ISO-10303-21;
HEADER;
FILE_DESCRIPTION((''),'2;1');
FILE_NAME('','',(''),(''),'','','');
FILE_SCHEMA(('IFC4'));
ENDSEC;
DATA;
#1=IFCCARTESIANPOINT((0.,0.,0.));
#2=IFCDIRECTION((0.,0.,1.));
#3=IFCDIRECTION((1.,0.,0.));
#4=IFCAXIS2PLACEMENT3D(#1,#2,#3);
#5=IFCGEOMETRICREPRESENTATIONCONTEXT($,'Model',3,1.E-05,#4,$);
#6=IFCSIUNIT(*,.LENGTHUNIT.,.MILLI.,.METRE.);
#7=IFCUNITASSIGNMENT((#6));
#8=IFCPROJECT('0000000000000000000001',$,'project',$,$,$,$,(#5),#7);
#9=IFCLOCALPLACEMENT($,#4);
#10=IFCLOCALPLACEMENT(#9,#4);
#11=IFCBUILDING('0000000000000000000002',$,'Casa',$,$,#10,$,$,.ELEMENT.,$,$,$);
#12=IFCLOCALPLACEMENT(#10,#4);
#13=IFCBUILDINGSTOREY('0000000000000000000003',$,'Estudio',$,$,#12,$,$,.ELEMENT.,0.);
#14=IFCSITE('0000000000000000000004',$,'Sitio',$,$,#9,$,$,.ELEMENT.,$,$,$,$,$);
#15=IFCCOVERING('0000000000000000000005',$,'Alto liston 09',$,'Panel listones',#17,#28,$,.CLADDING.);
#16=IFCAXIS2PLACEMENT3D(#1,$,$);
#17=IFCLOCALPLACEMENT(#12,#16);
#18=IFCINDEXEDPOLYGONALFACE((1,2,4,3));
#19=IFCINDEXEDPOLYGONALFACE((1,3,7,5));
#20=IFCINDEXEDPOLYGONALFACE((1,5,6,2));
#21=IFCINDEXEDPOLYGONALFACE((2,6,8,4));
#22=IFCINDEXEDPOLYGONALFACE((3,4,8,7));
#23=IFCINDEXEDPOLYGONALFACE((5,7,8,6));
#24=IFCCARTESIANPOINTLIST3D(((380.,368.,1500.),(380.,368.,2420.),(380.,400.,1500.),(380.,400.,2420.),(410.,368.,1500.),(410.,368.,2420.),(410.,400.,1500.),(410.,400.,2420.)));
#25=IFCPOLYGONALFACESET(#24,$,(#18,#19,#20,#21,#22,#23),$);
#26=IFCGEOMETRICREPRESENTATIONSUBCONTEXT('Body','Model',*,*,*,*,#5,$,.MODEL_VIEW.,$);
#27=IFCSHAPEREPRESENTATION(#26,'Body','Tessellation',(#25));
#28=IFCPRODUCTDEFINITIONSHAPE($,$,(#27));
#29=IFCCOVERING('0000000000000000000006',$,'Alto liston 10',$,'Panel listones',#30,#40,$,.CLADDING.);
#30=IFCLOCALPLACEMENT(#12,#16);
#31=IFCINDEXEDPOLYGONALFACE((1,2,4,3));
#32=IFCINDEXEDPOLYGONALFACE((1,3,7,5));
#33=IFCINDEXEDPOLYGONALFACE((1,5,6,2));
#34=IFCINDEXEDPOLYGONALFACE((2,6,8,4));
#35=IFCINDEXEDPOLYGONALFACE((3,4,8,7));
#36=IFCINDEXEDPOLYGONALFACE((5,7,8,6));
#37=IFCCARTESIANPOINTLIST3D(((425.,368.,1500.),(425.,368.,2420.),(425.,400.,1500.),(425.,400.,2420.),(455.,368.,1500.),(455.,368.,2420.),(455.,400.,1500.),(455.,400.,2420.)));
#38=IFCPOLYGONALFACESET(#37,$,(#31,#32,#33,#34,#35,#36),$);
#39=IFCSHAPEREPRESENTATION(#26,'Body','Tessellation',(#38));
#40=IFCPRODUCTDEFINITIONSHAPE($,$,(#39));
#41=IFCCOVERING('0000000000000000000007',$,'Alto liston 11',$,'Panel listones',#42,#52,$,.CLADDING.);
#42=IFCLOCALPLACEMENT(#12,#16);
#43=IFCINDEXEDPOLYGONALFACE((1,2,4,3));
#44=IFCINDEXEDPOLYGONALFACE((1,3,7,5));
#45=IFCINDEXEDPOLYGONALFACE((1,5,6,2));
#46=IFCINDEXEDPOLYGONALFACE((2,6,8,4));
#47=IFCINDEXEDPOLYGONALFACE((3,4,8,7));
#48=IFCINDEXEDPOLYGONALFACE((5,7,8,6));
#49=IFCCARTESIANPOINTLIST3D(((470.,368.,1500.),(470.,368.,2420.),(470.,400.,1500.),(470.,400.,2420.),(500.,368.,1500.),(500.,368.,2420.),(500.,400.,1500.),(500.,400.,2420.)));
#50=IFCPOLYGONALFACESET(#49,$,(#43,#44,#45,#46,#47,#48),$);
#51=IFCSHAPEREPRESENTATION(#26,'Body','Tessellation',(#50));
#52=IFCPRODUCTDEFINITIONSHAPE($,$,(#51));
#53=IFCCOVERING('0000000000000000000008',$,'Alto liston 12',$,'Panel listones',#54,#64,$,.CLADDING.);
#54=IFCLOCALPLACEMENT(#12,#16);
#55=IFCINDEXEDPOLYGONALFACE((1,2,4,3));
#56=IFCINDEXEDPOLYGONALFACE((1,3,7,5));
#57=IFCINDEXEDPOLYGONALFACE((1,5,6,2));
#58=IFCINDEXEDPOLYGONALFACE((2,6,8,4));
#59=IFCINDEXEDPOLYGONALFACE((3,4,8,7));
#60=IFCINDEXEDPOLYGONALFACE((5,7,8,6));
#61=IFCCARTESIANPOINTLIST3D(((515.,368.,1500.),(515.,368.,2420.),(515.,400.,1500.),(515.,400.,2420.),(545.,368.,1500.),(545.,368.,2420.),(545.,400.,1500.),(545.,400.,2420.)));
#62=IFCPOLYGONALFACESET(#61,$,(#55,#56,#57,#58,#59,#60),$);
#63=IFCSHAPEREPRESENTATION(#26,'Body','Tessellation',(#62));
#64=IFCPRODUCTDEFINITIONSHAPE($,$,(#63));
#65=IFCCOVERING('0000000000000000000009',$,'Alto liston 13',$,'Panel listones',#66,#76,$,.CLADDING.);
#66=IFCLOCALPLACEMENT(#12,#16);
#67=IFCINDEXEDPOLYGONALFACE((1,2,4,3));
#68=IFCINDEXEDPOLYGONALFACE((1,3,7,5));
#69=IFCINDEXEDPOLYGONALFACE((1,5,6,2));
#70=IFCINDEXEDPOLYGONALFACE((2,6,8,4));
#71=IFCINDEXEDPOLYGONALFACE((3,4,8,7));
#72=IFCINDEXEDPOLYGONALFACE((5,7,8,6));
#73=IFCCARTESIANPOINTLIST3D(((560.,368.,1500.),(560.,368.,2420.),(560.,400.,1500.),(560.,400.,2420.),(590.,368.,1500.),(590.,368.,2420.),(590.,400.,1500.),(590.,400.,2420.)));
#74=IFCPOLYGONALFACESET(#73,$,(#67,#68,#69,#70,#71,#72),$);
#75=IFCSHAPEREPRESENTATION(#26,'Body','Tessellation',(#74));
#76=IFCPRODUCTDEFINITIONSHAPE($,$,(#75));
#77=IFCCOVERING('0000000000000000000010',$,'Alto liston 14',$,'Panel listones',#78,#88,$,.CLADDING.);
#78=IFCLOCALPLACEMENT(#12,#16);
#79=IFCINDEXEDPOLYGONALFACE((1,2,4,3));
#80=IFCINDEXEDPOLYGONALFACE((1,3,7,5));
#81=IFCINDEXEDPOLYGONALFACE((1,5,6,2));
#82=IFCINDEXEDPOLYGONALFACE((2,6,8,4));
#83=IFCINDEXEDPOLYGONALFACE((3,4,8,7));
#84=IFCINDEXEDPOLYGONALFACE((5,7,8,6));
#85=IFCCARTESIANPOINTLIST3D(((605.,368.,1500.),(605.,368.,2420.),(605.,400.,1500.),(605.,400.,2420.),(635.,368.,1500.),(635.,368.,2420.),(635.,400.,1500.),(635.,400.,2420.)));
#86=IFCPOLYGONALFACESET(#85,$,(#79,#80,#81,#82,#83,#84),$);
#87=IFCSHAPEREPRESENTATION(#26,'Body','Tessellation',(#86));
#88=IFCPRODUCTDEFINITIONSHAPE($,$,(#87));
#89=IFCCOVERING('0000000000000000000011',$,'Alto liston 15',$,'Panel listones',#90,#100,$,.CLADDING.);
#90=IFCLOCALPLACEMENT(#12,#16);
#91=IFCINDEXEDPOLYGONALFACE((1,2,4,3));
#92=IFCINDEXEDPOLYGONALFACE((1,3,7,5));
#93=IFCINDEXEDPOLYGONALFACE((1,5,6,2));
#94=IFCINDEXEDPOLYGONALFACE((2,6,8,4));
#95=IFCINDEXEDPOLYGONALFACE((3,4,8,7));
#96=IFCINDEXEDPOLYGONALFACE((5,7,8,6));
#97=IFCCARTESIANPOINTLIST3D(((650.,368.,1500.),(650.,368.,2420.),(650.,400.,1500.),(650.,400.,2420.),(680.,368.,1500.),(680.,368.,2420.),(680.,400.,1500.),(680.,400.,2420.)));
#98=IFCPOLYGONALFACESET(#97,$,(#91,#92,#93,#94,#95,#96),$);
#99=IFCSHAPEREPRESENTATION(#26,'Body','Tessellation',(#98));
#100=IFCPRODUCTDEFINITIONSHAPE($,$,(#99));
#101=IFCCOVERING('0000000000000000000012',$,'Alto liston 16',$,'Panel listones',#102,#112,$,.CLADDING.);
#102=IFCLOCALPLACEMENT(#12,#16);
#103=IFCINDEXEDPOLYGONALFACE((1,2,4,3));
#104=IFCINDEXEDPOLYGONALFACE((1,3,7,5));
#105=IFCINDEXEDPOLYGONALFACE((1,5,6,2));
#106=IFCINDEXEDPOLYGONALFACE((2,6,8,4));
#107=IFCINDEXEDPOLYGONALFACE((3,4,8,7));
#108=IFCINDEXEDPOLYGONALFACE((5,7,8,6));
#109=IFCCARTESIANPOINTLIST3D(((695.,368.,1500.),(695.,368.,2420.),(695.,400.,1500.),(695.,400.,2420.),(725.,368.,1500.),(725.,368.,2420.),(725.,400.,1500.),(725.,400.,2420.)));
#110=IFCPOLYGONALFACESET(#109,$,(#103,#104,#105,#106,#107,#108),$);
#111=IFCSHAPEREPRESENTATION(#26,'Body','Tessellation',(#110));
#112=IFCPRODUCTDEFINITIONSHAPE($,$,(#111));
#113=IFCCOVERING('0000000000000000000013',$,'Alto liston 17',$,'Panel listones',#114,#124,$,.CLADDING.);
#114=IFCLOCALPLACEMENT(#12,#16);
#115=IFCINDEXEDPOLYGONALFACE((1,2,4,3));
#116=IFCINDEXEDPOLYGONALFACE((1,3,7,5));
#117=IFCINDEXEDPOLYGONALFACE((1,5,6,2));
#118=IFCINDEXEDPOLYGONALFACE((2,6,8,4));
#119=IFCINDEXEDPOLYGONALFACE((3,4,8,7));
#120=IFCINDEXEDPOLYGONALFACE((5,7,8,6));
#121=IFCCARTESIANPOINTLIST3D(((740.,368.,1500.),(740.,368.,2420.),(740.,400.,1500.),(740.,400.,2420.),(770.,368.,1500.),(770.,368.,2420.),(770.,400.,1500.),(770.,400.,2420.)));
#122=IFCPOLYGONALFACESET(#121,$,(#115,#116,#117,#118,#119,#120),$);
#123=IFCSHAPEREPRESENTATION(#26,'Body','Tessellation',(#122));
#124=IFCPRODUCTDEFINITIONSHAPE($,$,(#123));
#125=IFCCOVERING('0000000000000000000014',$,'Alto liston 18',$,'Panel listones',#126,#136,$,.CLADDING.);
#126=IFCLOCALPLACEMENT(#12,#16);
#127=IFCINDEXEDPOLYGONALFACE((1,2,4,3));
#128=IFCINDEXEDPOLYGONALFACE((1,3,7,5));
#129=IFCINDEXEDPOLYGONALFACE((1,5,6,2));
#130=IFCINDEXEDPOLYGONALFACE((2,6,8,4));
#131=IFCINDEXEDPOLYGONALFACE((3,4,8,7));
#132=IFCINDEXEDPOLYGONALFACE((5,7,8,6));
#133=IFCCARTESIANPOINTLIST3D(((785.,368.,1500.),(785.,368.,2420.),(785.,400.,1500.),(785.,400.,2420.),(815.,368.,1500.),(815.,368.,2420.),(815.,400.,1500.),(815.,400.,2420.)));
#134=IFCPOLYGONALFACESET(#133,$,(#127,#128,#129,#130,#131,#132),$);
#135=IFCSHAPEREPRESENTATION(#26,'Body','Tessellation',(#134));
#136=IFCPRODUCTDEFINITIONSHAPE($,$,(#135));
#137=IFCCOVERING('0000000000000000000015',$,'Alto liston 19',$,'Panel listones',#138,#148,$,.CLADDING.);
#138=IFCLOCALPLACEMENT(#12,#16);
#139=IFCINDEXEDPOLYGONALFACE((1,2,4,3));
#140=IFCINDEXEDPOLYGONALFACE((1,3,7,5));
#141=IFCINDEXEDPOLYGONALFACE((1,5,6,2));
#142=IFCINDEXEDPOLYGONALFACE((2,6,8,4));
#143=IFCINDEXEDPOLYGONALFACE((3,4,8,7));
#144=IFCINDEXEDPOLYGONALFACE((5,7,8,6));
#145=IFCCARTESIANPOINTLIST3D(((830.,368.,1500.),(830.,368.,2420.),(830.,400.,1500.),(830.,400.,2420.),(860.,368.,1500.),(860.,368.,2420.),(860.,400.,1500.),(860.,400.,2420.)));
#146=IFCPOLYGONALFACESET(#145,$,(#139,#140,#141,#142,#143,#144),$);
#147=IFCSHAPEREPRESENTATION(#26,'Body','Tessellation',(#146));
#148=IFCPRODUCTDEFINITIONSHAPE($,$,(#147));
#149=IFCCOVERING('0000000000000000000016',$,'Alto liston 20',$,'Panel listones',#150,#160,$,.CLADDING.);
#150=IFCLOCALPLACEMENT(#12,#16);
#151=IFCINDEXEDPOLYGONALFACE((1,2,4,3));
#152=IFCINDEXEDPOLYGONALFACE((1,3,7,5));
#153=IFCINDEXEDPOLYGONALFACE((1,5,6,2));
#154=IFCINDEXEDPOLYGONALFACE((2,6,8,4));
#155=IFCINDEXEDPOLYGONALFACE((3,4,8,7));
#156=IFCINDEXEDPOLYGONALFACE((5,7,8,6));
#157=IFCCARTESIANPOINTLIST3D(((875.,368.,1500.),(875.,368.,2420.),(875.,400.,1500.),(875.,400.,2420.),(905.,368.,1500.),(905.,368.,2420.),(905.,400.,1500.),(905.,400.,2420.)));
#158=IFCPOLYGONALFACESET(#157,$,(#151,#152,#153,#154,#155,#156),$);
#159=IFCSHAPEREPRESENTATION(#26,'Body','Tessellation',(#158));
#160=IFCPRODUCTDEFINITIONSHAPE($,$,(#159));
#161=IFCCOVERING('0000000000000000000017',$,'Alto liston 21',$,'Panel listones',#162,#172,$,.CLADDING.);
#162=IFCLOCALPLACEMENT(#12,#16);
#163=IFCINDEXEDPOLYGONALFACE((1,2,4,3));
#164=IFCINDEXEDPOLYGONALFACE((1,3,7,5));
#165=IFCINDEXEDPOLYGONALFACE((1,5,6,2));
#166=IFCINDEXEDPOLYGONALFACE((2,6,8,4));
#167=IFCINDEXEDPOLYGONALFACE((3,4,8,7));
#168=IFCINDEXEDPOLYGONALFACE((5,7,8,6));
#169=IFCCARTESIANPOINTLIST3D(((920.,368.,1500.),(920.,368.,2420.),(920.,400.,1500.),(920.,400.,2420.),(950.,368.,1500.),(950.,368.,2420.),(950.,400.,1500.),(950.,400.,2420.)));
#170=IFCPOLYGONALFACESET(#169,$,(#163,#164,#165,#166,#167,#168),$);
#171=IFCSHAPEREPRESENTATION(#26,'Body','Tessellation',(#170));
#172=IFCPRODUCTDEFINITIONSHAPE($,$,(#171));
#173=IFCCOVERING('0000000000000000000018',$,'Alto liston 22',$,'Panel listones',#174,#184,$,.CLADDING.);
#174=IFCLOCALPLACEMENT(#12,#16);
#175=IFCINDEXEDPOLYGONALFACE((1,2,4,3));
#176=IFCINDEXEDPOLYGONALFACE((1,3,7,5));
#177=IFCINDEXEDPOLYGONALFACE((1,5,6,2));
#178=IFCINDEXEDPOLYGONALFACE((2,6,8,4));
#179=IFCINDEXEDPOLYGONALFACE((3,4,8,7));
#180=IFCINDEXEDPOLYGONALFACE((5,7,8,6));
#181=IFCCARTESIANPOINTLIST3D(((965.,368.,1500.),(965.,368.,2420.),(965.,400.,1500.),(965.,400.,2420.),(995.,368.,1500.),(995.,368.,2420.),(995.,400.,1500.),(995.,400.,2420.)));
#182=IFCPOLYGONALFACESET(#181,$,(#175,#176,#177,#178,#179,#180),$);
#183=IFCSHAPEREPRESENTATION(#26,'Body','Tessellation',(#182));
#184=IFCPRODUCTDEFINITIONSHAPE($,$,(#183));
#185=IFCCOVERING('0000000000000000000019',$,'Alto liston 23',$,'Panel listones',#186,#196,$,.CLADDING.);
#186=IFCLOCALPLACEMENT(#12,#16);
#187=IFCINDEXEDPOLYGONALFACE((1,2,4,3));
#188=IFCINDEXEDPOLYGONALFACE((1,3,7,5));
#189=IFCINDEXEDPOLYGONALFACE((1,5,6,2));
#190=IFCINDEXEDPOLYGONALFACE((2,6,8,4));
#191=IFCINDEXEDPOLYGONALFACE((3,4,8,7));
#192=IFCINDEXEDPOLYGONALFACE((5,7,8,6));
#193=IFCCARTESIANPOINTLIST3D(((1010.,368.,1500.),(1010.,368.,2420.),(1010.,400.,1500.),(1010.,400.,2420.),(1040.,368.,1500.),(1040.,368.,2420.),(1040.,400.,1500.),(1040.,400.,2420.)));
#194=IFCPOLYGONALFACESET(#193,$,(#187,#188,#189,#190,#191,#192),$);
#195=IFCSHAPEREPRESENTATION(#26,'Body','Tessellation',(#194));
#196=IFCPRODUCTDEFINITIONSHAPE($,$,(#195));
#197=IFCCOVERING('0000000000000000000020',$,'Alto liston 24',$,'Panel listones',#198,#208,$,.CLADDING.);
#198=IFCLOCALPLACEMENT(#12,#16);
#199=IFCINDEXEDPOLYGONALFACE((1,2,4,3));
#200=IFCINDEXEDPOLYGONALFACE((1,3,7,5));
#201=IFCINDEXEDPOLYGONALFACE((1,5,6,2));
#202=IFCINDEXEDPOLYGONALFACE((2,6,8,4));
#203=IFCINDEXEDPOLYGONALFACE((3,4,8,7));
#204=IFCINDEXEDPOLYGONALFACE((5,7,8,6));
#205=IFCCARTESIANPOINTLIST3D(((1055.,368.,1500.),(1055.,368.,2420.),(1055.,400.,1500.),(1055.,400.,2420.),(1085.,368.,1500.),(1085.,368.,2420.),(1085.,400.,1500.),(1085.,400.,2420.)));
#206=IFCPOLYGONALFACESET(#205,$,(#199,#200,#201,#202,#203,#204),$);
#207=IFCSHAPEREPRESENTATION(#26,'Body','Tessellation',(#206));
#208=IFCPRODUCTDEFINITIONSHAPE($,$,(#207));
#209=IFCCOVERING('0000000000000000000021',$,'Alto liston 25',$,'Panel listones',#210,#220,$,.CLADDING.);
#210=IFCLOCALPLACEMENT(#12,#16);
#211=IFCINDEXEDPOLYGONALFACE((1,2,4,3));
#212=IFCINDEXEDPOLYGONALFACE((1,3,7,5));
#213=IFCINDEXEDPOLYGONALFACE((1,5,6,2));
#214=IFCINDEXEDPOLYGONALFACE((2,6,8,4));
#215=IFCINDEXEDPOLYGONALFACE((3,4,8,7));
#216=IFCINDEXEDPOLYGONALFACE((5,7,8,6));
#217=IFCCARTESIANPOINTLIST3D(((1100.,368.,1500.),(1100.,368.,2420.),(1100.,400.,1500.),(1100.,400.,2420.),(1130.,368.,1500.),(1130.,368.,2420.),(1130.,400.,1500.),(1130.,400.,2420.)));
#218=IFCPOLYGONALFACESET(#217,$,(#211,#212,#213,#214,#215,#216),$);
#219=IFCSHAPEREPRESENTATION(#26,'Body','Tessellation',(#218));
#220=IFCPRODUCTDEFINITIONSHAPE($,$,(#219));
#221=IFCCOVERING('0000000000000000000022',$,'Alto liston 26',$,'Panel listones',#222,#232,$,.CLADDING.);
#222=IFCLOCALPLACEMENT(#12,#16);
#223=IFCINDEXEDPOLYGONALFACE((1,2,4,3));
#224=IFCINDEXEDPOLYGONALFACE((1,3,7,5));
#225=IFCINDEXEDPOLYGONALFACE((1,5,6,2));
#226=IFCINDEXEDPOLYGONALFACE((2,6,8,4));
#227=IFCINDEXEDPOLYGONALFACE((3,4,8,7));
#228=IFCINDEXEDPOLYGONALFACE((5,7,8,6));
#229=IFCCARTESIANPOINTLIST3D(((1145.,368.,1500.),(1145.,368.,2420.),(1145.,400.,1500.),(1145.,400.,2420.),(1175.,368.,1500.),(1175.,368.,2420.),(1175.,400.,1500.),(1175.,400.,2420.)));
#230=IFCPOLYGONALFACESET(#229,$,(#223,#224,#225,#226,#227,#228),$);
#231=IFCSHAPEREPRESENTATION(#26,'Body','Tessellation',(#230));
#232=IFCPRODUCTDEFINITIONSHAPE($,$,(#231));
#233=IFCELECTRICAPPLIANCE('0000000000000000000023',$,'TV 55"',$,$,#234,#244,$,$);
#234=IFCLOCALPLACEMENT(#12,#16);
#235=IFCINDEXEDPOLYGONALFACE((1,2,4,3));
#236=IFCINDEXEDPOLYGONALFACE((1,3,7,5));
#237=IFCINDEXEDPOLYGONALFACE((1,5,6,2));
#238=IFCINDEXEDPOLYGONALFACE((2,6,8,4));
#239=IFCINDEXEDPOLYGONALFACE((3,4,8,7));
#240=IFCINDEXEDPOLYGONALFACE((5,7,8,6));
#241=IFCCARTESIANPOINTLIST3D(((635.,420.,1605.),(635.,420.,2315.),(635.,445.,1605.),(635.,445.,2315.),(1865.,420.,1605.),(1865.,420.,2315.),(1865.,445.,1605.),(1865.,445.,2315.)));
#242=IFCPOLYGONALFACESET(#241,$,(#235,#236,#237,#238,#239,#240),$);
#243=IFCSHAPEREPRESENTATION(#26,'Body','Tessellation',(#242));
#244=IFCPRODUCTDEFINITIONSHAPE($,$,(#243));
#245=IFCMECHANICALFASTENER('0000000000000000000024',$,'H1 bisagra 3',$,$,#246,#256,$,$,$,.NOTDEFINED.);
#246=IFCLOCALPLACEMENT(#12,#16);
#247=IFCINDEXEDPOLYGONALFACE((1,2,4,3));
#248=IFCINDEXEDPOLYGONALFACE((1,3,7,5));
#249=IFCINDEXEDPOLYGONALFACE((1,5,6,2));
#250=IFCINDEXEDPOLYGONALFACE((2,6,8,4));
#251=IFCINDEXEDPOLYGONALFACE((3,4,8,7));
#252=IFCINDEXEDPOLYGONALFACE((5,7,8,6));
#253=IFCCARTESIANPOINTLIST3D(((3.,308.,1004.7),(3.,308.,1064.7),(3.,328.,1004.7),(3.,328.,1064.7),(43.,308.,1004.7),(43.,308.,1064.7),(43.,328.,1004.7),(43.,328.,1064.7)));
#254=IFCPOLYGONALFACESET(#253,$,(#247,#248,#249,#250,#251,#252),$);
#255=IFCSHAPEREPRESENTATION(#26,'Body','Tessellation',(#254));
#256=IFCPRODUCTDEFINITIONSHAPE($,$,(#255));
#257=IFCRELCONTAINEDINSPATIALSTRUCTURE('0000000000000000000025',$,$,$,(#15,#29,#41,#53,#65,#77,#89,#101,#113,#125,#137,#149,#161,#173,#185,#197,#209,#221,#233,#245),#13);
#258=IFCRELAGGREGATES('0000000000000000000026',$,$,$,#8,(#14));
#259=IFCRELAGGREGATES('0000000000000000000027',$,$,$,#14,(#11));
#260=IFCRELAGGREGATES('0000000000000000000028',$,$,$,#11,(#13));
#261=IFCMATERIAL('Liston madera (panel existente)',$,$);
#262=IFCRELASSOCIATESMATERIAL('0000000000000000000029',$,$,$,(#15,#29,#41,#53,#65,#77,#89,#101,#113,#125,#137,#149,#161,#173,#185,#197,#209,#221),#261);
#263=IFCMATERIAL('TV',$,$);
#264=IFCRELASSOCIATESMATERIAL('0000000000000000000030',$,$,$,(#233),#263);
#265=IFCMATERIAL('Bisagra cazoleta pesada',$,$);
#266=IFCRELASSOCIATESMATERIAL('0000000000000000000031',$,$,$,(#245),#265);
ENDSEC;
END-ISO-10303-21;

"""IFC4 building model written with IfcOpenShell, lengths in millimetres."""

from ifc_helpers import new_model, si_unit, frame, frame_2d, origin_with_axes, place, context, subcontext, project, spatial, rectangle, extrude, material, element, save


model = new_model("IFC4")

# Units and contexts
model_context = context("Model", 3, precision=1e-05, world=origin_with_axes())
body_context = subcontext(model_context, "Body", "Model", "MODEL_VIEW")
ifc_project = project(units=[si_unit("LENGTHUNIT", "METRE", prefix="MILLI")], contexts=[model_context])

# Site, building, storey
site_placement = place(None, origin_with_axes())
site = spatial("IfcSite", under=ifc_project, at=site_placement, Name="Sitio", CompositionType="ELEMENT")
building_placement = place(site_placement, origin_with_axes())
building = spatial("IfcBuilding", under=site, at=building_placement, Name="Casa", CompositionType="ELEMENT")
storey_placement = place(building_placement, origin_with_axes())
storey = spatial("IfcBuildingStorey", under=building, at=storey_placement, Name="Estudio", CompositionType="ELEMENT", Elevation=0.0)

# Coverings
ifc_material_1 = material(Name="Liston madera (panel existente)")
for number, where, z_axis, x_axis, name in (
    (1, (380.0, 368.0, 1500.0), (0.0, 0.0, 1.0), (1.0, 0.0, 0.0), "Alto liston 09"),
    (2, (425.0, 368.0, 1500.0), (0.0, 0.0, 1.0), (1.0, 0.0, 0.0), "Alto liston 10"),
    (3, (470.0, 368.0, 1500.0), (0.0, 0.0, 1.0), (1.0, 0.0, 0.0), "Alto liston 11"),
    (4, (515.0, 368.0, 1500.0), (0.0, 0.0, 1.0), (1.0, 0.0, 0.0), "Alto liston 12"),
    (5, (560.0, 368.0, 1500.0), (0.0, 0.0, 1.0), (1.0, 0.0, 0.0), "Alto liston 13"),
    (6, (605.0, 368.0, 1500.0), (0.0, 0.0, 1.0), (1.0, 0.0, 0.0), "Alto liston 14"),
    (7, (650.0, 368.0, 1500.0), (0.0, 0.0, 1.0), (1.0, 0.0, 0.0), "Alto liston 15"),
    (8, (695.0, 368.0, 1500.0), (0.0, 0.0, 1.0), (1.0, 0.0, 0.0), "Alto liston 16"),
    (9, (740.0, 368.0, 1500.0), (0.0, 0.0, 1.0), (1.0, 0.0, 0.0), "Alto liston 17"),
    (10, (785.0, 368.0, 1500.0), (0.0, 0.0, 1.0), (1.0, 0.0, 0.0), "Alto liston 18"),
    (11, (830.0, 368.0, 1500.0), (0.0, 0.0, 1.0), (1.0, 0.0, 0.0), "Alto liston 19"),
    (12, (875.0, 368.0, 1500.0), (0.0, 0.0, 1.0), (1.0, 0.0, 0.0), "Alto liston 20"),
    (13, (920.0, 368.0, 1500.0), (0.0, 0.0, 1.0), (1.0, 0.0, 0.0), "Alto liston 21"),
    (14, (965.0, 368.0, 1500.0), (0.0, 0.0, 1.0), (1.0, 0.0, 0.0), "Alto liston 22"),
    (15, (1010.0, 368.0, 1500.0), (0.0, 0.0, 1.0), (1.0, 0.0, 0.0), "Alto liston 23"),
    (16, (1055.0, 368.0, 1500.0), (0.0, 0.0, 1.0), (1.0, 0.0, 0.0), "Alto liston 24"),
    (17, (1100.0, 368.0, 1500.0), (0.0, 0.0, 1.0), (1.0, 0.0, 0.0), "Alto liston 25"),
    (18, (1145.0, 368.0, 1500.0), (0.0, 0.0, 1.0), (1.0, 0.0, 0.0), "Alto liston 26"),
):
    element("IfcCovering", number, at=place(storey_placement, frame(where, z_axis=z_axis, x_axis=x_axis)), inside=storey, material=ifc_material_1, Name=name, ObjectType="Panel listones", PredefinedType="CLADDING", context=body_context, shape_type="SweptSolid", body=[
        extrude(rectangle(XDim=30.0, YDim=32.0, at=frame_2d((15.0, 16.0))), origin_with_axes(), (0.0, 0.0, 1.0), 920.0),
    ])

# Electric appliance
ifc_material_2 = material(Name="TV")
electric_appliance_placement = place(storey_placement, frame((635.0, 420.0, 1605.0), z_axis=(0.0, 0.0, 1.0), x_axis=(1.0, 0.0, 0.0)))
element("IfcElectricAppliance", 19, at=electric_appliance_placement, inside=storey, material=ifc_material_2, Name="TV 55\"", context=body_context, shape_type="SweptSolid", body=[
    extrude(rectangle(XDim=1230.0, YDim=25.0, at=frame_2d((615.0, 12.5))), origin_with_axes(), (0.0, 0.0, 1.0), 710.0),
])

# Mechanical fastener
ifc_material_3 = material(Name="Bisagra cazoleta pesada")
for number, where, z_axis, x_axis, name in (
    (20, (3.0, 308.0, 1004.7), (0.0, 0.0, 1.0), (1.0, 0.0, 0.0), "H1 bisagra 3"),
):
    element("IfcMechanicalFastener", number, at=place(storey_placement, frame(where, z_axis=z_axis, x_axis=x_axis)), inside=storey, material=ifc_material_3, Name=name, PredefinedType="NOTDEFINED", context=body_context, shape_type="SweptSolid", body=[
        extrude(rectangle(XDim=40.0, YDim=20.0, at=frame_2d((20.0, 10.0))), origin_with_axes(), (0.0, 0.0, 1.0), 60.0),
    ])

save(model, "model.ifc")
